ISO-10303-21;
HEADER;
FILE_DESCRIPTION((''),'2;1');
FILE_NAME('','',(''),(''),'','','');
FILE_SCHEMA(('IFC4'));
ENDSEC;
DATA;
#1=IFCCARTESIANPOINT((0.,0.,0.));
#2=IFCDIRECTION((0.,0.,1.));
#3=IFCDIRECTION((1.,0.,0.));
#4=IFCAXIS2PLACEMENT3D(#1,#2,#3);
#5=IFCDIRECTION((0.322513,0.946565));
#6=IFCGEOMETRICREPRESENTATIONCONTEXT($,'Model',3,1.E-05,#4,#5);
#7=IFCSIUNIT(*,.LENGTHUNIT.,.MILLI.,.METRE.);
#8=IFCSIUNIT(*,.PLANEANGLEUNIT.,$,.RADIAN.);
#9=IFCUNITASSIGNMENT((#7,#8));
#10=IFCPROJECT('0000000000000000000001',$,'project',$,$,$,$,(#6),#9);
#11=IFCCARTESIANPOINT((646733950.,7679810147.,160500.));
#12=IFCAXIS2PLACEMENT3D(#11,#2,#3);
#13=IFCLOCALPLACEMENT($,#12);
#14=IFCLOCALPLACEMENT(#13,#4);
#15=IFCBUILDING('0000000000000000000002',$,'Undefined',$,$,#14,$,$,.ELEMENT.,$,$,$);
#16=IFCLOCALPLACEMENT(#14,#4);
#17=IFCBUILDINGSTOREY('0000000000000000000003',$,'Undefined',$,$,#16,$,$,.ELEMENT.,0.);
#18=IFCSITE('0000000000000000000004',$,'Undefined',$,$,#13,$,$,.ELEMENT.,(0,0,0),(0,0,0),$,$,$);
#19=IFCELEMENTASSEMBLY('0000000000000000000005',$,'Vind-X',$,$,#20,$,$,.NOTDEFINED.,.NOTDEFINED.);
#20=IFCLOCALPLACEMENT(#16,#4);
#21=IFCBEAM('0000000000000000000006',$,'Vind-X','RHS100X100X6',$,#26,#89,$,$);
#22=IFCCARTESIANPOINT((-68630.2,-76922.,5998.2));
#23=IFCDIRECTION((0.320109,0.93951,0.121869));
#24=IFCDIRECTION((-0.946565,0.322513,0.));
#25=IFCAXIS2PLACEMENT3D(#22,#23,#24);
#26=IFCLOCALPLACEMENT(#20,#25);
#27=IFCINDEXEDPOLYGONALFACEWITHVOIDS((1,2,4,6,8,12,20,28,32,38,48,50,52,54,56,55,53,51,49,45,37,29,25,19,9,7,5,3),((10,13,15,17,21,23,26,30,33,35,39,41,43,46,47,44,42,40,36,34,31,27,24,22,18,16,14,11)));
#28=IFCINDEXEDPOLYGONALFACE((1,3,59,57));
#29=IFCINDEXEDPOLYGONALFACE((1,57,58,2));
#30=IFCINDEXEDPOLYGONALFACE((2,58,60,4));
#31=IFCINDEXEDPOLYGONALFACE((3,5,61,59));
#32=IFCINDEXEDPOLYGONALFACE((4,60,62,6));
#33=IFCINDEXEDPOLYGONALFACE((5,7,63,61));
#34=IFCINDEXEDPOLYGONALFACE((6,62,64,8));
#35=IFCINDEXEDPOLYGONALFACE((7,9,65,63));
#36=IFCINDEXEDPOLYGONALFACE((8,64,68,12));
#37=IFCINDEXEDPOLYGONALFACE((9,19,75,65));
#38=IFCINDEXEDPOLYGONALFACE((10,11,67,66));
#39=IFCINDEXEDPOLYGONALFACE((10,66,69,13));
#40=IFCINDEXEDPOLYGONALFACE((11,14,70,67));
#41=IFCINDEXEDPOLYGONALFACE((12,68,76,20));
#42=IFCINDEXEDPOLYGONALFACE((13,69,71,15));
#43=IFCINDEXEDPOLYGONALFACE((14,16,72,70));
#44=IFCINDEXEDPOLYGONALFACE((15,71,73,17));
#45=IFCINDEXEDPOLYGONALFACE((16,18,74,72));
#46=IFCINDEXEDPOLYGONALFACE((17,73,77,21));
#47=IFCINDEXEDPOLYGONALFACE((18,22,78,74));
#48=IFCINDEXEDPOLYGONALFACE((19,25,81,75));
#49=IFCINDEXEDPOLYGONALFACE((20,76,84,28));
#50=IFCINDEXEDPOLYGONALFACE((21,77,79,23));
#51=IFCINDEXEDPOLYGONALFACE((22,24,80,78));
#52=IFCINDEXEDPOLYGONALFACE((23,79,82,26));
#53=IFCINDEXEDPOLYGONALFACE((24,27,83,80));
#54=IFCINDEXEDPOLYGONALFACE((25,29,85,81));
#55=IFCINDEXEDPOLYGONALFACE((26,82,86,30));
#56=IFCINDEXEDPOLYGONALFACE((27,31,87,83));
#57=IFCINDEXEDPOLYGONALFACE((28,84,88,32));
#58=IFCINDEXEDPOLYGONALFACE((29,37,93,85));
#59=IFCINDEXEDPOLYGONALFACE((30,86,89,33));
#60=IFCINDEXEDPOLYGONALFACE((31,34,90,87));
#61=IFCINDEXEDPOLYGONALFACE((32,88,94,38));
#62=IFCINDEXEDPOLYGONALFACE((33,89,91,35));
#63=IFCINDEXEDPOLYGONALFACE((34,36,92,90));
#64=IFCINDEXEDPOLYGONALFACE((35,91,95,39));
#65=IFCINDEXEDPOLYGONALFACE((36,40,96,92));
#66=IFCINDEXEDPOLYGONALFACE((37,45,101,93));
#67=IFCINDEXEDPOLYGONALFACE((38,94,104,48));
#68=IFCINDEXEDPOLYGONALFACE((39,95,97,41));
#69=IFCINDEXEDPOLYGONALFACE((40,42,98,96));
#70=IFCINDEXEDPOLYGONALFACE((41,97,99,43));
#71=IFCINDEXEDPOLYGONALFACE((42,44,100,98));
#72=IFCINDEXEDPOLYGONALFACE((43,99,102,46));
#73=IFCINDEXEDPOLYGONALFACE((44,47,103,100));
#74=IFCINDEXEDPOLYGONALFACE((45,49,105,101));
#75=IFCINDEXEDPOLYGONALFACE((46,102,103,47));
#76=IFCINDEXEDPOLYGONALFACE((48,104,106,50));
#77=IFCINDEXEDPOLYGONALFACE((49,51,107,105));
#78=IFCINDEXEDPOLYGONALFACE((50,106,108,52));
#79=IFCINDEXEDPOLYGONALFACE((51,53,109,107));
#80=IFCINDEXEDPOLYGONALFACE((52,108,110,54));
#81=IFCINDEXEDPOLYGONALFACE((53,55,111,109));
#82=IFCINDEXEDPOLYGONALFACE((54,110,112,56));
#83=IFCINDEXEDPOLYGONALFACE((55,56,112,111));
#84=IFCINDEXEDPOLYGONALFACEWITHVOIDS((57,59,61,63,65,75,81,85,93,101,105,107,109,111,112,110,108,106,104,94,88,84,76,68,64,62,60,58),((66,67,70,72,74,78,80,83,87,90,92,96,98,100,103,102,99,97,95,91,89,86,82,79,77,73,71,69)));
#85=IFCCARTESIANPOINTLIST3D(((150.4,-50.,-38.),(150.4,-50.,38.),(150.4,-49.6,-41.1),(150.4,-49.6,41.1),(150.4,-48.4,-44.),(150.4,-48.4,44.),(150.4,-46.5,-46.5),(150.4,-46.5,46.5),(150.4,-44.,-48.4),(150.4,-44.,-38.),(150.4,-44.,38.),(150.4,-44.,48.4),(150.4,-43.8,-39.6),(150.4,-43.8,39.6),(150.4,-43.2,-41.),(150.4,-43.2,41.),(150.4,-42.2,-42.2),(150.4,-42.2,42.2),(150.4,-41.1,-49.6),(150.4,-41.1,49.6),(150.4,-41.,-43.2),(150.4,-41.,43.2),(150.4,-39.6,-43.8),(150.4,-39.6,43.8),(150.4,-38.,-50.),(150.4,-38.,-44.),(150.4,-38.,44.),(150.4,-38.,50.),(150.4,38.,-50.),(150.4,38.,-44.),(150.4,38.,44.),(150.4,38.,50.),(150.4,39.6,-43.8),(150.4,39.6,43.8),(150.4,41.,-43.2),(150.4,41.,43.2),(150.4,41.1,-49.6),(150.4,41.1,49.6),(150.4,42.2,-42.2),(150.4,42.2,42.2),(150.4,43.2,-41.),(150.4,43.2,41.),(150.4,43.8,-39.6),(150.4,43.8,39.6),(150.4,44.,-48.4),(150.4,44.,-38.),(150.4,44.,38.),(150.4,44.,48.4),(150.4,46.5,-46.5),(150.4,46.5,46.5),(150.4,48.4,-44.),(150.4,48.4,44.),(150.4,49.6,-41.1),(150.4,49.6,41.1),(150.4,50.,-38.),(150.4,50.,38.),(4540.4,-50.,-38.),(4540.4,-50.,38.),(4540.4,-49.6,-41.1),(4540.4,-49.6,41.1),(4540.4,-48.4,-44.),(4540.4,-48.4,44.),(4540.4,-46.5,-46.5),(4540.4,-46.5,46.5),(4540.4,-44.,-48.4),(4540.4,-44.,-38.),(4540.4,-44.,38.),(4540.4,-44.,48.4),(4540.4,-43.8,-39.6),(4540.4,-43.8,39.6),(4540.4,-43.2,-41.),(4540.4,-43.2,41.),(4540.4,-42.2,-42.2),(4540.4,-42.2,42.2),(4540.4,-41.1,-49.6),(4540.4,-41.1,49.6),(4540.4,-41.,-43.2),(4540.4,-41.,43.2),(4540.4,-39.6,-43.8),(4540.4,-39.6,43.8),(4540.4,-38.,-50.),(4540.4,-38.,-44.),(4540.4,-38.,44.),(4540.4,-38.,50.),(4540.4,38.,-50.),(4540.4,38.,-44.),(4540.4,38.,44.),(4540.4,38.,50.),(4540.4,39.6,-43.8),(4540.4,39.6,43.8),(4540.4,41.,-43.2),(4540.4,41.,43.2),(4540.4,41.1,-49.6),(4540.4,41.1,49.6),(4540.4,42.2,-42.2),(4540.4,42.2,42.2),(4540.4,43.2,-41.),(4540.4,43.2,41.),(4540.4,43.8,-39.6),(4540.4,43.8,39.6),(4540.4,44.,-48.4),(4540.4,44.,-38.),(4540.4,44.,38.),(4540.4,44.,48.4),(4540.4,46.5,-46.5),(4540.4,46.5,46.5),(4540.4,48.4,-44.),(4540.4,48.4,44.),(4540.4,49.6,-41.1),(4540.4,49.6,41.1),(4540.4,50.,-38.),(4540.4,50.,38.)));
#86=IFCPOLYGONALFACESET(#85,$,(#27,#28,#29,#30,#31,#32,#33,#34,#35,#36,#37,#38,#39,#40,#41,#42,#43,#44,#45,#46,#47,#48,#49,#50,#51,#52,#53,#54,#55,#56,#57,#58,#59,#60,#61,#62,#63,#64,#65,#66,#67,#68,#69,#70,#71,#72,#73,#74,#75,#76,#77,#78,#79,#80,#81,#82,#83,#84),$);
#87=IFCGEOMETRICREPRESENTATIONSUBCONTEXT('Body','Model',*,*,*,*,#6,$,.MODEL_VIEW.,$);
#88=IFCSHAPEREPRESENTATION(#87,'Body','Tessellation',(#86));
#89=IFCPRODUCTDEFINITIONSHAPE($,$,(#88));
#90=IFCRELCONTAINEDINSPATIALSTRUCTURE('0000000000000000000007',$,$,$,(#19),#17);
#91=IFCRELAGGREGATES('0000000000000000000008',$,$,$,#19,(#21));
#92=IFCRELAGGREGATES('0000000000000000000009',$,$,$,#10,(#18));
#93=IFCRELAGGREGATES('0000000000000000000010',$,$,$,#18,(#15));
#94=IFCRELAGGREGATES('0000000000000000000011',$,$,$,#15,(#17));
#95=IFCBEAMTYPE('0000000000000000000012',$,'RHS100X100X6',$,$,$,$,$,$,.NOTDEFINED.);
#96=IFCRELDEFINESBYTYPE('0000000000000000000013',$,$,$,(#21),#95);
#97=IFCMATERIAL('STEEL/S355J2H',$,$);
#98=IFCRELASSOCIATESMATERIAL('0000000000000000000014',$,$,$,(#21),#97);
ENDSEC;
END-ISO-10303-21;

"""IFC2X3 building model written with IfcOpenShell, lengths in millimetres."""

from ifc_helpers import new_model, si_unit, direction, frame, origin_with_axes, origin_2d_with_axis, place, context, subcontext, project, spatial, hollow_rectangle, extrude, clip, halfspace, material, type_object, element, aggregate, save


model = new_model("IFC2X3")

# Units and contexts
model_context = context("Model", 3, precision=1e-05, world=origin_with_axes(), true_north=direction((0.322513, 0.946565)))
body_context = subcontext(model_context, "Body", "Model", "MODEL_VIEW")
ifc_project = project(units=[si_unit("LENGTHUNIT", "METRE", prefix="MILLI"), si_unit("PLANEANGLEUNIT", "RADIAN")], contexts=[model_context])

# Site, building, storey
site_placement = place(None, frame((646733950.0, 7679810147.0, 160500.0), z_axis=(0.0, 0.0, 1.0), x_axis=(1.0, 0.0, 0.0)))
site = spatial("IfcSite", under=ifc_project, at=site_placement, Name="Undefined", CompositionType="ELEMENT", RefLatitude=(0, 0, 0), RefLongitude=(0, 0, 0))
building_placement = place(site_placement, origin_with_axes())
building = spatial("IfcBuilding", under=site, at=building_placement, Name="Undefined", CompositionType="ELEMENT")
storey_placement = place(building_placement, origin_with_axes())
storey = spatial("IfcBuildingStorey", under=building, at=storey_placement, Name="Undefined", CompositionType="ELEMENT", Elevation=0.0)

# Shared definitions
ifc_material_1 = material(Name="STEEL/S355J2H")

# Element assembly, beam
assembly_1_placement = place(storey_placement, origin_with_axes())
assembly_1 = element("IfcElementAssembly", 1, at=assembly_1_placement, inside=storey, Name="Vind-X", AssemblyPlace="NOTDEFINED", PredefinedType="NOTDEFINED")
beam_type_1 = type_object("IfcBeamType", Name="RHS100X100X6", PredefinedType="NOTDEFINED")
beam_1_placement = place(assembly_1_placement, frame((-68630.2, -76922.0, 5998.2), z_axis=(0.320109, 0.93951, 0.121869), x_axis=(-0.946565, 0.322513, 0.0)))
beam_1 = element("IfcBeam", 2, at=beam_1_placement, type_object=beam_type_1, material=ifc_material_1, Name="Vind-X", Description="RHS100X100X6", context=body_context, shape_type="Clipping", body=[
    clip(clip(extrude(hollow_rectangle(XDim=100.0, YDim=100.0, WallThickness=6.0, InnerFilletRadius=6.0, OuterFilletRadius=12.0, at=origin_2d_with_axis()), frame((4690.0, 0.0, 0.0), z_axis=(-1.0, 0.0, 0.0), x_axis=(0.0, -1.0, 0.0)), (0.0, 0.0, 1.0), 4690.0), halfspace(frame((4540.4, -22.5, 0.0), z_axis=(-1.0, 0.0, 0.0), x_axis=(0.0, 0.0, -1.0)), True)), halfspace(frame((150.4, -22.5, 0.0), z_axis=(1.0, 0.0, 0.0), x_axis=(0.0, 1.0, 0.0)), True)),
])

aggregate(assembly_1, [beam_1])

save(model, "model.ifc")
